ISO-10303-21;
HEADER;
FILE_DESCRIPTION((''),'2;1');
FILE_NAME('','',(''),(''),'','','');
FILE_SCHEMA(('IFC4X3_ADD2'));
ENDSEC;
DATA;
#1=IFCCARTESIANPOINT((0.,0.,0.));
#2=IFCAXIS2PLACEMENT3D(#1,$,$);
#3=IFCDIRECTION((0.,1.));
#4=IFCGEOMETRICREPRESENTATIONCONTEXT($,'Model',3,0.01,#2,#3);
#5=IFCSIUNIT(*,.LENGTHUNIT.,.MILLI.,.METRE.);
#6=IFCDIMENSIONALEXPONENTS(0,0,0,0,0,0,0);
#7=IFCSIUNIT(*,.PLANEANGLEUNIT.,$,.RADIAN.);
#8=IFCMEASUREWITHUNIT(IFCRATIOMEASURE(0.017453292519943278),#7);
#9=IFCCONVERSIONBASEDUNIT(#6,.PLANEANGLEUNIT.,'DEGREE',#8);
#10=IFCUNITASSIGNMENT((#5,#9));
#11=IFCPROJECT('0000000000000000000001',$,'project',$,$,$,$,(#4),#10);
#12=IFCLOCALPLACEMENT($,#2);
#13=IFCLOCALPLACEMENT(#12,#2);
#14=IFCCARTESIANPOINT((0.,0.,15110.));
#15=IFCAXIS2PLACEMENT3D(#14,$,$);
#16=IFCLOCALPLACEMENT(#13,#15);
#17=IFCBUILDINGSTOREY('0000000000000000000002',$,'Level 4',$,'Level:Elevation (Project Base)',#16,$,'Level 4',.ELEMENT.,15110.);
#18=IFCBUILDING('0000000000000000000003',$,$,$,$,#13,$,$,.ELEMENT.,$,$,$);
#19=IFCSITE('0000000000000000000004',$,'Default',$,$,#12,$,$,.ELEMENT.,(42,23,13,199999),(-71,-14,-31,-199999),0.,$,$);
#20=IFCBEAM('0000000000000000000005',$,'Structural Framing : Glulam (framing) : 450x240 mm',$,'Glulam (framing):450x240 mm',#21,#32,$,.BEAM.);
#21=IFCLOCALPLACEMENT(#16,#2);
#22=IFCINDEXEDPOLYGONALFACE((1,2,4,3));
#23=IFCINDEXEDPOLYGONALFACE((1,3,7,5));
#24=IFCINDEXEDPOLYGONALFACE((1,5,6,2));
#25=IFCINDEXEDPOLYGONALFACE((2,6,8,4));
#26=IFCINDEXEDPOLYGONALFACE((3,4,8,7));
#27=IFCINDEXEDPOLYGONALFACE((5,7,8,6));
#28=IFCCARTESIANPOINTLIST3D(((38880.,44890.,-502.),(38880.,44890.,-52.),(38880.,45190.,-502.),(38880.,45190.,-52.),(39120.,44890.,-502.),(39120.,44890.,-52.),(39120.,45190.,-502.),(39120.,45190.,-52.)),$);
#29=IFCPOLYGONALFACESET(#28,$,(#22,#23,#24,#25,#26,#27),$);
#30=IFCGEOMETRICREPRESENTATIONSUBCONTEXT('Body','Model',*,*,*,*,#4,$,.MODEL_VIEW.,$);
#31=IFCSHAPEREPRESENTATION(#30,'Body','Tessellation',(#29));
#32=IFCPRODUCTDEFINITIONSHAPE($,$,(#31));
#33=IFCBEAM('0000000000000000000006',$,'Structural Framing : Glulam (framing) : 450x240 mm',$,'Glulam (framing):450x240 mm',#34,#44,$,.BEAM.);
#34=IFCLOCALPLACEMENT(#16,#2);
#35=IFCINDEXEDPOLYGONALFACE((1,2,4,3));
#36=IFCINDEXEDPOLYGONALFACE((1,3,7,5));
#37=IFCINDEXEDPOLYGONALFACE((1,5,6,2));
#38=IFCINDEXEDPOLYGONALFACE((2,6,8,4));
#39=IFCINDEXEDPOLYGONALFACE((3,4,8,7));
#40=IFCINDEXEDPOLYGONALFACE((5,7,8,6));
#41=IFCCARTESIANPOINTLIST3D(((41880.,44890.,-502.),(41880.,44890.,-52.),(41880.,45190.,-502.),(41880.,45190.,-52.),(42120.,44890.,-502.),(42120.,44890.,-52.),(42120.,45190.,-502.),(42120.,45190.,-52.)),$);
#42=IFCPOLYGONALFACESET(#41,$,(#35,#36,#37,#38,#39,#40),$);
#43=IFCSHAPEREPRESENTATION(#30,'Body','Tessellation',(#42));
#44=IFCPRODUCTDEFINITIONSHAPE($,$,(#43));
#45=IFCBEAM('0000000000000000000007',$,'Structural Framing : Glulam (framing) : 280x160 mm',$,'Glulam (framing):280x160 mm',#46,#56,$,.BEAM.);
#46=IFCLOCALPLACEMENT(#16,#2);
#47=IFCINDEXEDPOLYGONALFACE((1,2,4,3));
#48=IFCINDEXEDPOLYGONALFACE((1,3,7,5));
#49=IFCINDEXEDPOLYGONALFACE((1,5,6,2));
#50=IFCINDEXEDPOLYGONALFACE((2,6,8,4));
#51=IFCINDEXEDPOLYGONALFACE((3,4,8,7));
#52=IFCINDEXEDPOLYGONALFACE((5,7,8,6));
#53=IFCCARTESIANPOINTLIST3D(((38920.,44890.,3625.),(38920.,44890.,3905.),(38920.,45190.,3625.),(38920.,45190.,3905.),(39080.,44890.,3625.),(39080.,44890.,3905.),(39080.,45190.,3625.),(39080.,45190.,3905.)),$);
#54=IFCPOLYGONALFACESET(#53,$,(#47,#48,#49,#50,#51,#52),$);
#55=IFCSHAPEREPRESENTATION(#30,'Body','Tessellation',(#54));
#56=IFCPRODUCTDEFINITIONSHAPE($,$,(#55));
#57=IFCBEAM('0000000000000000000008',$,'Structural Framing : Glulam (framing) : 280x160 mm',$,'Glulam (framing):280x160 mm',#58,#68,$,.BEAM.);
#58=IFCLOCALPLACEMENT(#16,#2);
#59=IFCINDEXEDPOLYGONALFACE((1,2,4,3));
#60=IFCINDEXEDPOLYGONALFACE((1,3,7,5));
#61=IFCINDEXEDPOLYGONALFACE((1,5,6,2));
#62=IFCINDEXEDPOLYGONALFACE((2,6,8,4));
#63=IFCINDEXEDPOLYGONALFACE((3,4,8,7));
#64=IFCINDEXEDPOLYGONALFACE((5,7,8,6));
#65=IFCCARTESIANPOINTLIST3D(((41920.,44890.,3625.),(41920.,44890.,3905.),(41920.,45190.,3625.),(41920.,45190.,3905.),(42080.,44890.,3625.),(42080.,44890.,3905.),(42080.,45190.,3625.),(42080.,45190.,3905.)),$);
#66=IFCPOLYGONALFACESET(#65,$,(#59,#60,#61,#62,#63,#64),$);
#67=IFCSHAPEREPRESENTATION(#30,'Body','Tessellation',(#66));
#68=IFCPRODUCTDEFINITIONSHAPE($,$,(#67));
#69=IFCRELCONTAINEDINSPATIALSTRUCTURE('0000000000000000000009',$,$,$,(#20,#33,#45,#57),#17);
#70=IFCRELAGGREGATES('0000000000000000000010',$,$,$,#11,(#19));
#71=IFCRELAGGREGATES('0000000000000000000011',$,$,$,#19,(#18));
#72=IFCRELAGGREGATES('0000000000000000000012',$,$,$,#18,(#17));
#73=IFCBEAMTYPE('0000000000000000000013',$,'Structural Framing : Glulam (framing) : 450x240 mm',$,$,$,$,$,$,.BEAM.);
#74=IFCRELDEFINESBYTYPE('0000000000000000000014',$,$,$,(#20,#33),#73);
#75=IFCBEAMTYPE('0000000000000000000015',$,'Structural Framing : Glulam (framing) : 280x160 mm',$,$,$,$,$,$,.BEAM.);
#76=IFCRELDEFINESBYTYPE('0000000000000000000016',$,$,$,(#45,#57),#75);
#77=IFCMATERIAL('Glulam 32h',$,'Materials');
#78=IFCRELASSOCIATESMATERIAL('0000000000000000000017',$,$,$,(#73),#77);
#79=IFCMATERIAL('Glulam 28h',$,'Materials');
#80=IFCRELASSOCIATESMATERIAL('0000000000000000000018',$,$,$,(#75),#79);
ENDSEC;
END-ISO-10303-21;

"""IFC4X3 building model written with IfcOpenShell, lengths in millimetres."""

from ifc_helpers import new_model, entity, si_unit, converted_unit, direction, frame, origin, origin_2d_with_axis, place, context, subcontext, project, spatial, rectangle, extrude, source, transform, mapped, material, material_profile, profile_set, type_object, type_shapes, element, save


model = new_model("IFC4X3")

# Units and contexts
model_context = context("Model", 3, precision=0.01, world=origin(), true_north=direction((0.0, 1.0)))
body_context = subcontext(model_context, "Body", "Model", "MODEL_VIEW")
ifc_project = project(units=[si_unit("LENGTHUNIT", "METRE", prefix="MILLI"), converted_unit("PLANEANGLEUNIT", "DEGREE", entity("IfcRatioMeasure", 0.017453292519943278), si_unit("PLANEANGLEUNIT", "RADIAN"), dimensions=[0, 0, 0, 0, 0, 0, 0])], contexts=[model_context])

# Site, building, storey
site_placement = place(None, origin())
site = spatial("IfcSite", under=ifc_project, at=site_placement, Name="Default", CompositionType="ELEMENT", RefLatitude=(42, 23, 13, 199999), RefLongitude=(-71, -14, -31, -199999), RefElevation=0.0)
building_placement = place(site_placement, origin())
building = spatial("IfcBuilding", under=site, at=building_placement, CompositionType="ELEMENT")
storey_placement = place(building_placement, frame((0.0, 0.0, 15110.0)))
storey = spatial("IfcBuildingStorey", under=building, at=storey_placement, Name="Level 4", ObjectType="Level:Elevation (Project Base)", LongName="Level 4", CompositionType="ELEMENT", Elevation=15110.0)

# Beams
ifc_material_1 = material(Name="Glulam 28h", Category="Materials")
ifc_material_profile_1 = material_profile(ifc_material_1, rectangle(XDim=280.0, YDim=160.0, at=origin_2d_with_axis()), Name="280x160 mm")
ifc_profile_set_1 = profile_set([ifc_material_profile_1], Name="280x160 mm")
ifc_material_2 = material(Name="Glulam 32h", Category="Materials")
ifc_material_profile_2 = material_profile(ifc_material_2, rectangle(XDim=450.0, YDim=240.0, at=origin_2d_with_axis()), Name="450x240 mm")
ifc_profile_set_2 = profile_set([ifc_material_profile_2], Name="450x240 mm")
beam_type_1 = type_object("IfcBeamType", Name="Structural Framing : Glulam (framing) : 450x240 mm", PredefinedType="BEAM", material=ifc_profile_set_2)
shared_shape_1 = source(origin(), body_context, "Body", "SweptSolid", [
    extrude(rectangle(XDim=450.0, YDim=240.0, at=origin_2d_with_axis()), frame((-1110.0, 0.0, 0.0), z_axis=(1.0, 0.0, 0.0), x_axis=(0.0, 0.0, -1.0)), (0.0, 0.0, 1.0), 300.0),
])
type_shapes(beam_type_1, [shared_shape_1])
for number, where, z_axis, x_axis, name in (
    (1, (39000.0, 44080.0, -277.0), (0.0, 0.0, 1.0), (0.0, -1.0, 0.0), "Structural Framing : Glulam (framing) : 450x240 mm"),
    (2, (42000.0, 44080.0, -277.0), (0.0, 0.0, 1.0), (0.0, -1.0, 0.0), "Structural Framing : Glulam (framing) : 450x240 mm"),
):
    element("IfcBeam", number, at=place(storey_placement, frame(where, z_axis=z_axis, x_axis=x_axis)), inside=storey, type_object=beam_type_1, Name=name, ObjectType="Glulam (framing):450x240 mm", PredefinedType="BEAM", context=body_context, shape_type="MappedRepresentation", body=[
        mapped(shared_shape_1, transform((0.0, 0.0, 0.0), scale=1.0)),
    ])
beam_type_2 = type_object("IfcBeamType", Name="Structural Framing : Glulam (framing) : 280x160 mm", PredefinedType="BEAM", material=ifc_profile_set_1)
shared_shape_2 = source(origin(), body_context, "Body", "SweptSolid", [
    extrude(rectangle(XDim=280.0, YDim=160.0, at=origin_2d_with_axis()), frame((5322.5, 0.0, 0.0), z_axis=(1.0, 0.0, 0.0), x_axis=(0.0, 0.0, -1.0)), (0.0, 0.0, 1.0), 300.0),
])
type_shapes(beam_type_2, [shared_shape_2])
for number, where, z_axis, x_axis, name in (
    (3, (39000.0, 50512.5, 3765.0), (0.0, 0.0, 1.0), (0.0, -1.0, 0.0), "Structural Framing : Glulam (framing) : 280x160 mm"),
    (4, (42000.0, 50512.5, 3765.0), (0.0, 0.0, 1.0), (0.0, -1.0, 0.0), "Structural Framing : Glulam (framing) : 280x160 mm"),
):
    element("IfcBeam", number, at=place(storey_placement, frame(where, z_axis=z_axis, x_axis=x_axis)), inside=storey, type_object=beam_type_2, Name=name, ObjectType="Glulam (framing):280x160 mm", PredefinedType="BEAM", context=body_context, shape_type="MappedRepresentation", body=[
        mapped(shared_shape_2, transform((0.0, 0.0, 0.0), scale=1.0)),
    ])

save(model, "model.ifc")
